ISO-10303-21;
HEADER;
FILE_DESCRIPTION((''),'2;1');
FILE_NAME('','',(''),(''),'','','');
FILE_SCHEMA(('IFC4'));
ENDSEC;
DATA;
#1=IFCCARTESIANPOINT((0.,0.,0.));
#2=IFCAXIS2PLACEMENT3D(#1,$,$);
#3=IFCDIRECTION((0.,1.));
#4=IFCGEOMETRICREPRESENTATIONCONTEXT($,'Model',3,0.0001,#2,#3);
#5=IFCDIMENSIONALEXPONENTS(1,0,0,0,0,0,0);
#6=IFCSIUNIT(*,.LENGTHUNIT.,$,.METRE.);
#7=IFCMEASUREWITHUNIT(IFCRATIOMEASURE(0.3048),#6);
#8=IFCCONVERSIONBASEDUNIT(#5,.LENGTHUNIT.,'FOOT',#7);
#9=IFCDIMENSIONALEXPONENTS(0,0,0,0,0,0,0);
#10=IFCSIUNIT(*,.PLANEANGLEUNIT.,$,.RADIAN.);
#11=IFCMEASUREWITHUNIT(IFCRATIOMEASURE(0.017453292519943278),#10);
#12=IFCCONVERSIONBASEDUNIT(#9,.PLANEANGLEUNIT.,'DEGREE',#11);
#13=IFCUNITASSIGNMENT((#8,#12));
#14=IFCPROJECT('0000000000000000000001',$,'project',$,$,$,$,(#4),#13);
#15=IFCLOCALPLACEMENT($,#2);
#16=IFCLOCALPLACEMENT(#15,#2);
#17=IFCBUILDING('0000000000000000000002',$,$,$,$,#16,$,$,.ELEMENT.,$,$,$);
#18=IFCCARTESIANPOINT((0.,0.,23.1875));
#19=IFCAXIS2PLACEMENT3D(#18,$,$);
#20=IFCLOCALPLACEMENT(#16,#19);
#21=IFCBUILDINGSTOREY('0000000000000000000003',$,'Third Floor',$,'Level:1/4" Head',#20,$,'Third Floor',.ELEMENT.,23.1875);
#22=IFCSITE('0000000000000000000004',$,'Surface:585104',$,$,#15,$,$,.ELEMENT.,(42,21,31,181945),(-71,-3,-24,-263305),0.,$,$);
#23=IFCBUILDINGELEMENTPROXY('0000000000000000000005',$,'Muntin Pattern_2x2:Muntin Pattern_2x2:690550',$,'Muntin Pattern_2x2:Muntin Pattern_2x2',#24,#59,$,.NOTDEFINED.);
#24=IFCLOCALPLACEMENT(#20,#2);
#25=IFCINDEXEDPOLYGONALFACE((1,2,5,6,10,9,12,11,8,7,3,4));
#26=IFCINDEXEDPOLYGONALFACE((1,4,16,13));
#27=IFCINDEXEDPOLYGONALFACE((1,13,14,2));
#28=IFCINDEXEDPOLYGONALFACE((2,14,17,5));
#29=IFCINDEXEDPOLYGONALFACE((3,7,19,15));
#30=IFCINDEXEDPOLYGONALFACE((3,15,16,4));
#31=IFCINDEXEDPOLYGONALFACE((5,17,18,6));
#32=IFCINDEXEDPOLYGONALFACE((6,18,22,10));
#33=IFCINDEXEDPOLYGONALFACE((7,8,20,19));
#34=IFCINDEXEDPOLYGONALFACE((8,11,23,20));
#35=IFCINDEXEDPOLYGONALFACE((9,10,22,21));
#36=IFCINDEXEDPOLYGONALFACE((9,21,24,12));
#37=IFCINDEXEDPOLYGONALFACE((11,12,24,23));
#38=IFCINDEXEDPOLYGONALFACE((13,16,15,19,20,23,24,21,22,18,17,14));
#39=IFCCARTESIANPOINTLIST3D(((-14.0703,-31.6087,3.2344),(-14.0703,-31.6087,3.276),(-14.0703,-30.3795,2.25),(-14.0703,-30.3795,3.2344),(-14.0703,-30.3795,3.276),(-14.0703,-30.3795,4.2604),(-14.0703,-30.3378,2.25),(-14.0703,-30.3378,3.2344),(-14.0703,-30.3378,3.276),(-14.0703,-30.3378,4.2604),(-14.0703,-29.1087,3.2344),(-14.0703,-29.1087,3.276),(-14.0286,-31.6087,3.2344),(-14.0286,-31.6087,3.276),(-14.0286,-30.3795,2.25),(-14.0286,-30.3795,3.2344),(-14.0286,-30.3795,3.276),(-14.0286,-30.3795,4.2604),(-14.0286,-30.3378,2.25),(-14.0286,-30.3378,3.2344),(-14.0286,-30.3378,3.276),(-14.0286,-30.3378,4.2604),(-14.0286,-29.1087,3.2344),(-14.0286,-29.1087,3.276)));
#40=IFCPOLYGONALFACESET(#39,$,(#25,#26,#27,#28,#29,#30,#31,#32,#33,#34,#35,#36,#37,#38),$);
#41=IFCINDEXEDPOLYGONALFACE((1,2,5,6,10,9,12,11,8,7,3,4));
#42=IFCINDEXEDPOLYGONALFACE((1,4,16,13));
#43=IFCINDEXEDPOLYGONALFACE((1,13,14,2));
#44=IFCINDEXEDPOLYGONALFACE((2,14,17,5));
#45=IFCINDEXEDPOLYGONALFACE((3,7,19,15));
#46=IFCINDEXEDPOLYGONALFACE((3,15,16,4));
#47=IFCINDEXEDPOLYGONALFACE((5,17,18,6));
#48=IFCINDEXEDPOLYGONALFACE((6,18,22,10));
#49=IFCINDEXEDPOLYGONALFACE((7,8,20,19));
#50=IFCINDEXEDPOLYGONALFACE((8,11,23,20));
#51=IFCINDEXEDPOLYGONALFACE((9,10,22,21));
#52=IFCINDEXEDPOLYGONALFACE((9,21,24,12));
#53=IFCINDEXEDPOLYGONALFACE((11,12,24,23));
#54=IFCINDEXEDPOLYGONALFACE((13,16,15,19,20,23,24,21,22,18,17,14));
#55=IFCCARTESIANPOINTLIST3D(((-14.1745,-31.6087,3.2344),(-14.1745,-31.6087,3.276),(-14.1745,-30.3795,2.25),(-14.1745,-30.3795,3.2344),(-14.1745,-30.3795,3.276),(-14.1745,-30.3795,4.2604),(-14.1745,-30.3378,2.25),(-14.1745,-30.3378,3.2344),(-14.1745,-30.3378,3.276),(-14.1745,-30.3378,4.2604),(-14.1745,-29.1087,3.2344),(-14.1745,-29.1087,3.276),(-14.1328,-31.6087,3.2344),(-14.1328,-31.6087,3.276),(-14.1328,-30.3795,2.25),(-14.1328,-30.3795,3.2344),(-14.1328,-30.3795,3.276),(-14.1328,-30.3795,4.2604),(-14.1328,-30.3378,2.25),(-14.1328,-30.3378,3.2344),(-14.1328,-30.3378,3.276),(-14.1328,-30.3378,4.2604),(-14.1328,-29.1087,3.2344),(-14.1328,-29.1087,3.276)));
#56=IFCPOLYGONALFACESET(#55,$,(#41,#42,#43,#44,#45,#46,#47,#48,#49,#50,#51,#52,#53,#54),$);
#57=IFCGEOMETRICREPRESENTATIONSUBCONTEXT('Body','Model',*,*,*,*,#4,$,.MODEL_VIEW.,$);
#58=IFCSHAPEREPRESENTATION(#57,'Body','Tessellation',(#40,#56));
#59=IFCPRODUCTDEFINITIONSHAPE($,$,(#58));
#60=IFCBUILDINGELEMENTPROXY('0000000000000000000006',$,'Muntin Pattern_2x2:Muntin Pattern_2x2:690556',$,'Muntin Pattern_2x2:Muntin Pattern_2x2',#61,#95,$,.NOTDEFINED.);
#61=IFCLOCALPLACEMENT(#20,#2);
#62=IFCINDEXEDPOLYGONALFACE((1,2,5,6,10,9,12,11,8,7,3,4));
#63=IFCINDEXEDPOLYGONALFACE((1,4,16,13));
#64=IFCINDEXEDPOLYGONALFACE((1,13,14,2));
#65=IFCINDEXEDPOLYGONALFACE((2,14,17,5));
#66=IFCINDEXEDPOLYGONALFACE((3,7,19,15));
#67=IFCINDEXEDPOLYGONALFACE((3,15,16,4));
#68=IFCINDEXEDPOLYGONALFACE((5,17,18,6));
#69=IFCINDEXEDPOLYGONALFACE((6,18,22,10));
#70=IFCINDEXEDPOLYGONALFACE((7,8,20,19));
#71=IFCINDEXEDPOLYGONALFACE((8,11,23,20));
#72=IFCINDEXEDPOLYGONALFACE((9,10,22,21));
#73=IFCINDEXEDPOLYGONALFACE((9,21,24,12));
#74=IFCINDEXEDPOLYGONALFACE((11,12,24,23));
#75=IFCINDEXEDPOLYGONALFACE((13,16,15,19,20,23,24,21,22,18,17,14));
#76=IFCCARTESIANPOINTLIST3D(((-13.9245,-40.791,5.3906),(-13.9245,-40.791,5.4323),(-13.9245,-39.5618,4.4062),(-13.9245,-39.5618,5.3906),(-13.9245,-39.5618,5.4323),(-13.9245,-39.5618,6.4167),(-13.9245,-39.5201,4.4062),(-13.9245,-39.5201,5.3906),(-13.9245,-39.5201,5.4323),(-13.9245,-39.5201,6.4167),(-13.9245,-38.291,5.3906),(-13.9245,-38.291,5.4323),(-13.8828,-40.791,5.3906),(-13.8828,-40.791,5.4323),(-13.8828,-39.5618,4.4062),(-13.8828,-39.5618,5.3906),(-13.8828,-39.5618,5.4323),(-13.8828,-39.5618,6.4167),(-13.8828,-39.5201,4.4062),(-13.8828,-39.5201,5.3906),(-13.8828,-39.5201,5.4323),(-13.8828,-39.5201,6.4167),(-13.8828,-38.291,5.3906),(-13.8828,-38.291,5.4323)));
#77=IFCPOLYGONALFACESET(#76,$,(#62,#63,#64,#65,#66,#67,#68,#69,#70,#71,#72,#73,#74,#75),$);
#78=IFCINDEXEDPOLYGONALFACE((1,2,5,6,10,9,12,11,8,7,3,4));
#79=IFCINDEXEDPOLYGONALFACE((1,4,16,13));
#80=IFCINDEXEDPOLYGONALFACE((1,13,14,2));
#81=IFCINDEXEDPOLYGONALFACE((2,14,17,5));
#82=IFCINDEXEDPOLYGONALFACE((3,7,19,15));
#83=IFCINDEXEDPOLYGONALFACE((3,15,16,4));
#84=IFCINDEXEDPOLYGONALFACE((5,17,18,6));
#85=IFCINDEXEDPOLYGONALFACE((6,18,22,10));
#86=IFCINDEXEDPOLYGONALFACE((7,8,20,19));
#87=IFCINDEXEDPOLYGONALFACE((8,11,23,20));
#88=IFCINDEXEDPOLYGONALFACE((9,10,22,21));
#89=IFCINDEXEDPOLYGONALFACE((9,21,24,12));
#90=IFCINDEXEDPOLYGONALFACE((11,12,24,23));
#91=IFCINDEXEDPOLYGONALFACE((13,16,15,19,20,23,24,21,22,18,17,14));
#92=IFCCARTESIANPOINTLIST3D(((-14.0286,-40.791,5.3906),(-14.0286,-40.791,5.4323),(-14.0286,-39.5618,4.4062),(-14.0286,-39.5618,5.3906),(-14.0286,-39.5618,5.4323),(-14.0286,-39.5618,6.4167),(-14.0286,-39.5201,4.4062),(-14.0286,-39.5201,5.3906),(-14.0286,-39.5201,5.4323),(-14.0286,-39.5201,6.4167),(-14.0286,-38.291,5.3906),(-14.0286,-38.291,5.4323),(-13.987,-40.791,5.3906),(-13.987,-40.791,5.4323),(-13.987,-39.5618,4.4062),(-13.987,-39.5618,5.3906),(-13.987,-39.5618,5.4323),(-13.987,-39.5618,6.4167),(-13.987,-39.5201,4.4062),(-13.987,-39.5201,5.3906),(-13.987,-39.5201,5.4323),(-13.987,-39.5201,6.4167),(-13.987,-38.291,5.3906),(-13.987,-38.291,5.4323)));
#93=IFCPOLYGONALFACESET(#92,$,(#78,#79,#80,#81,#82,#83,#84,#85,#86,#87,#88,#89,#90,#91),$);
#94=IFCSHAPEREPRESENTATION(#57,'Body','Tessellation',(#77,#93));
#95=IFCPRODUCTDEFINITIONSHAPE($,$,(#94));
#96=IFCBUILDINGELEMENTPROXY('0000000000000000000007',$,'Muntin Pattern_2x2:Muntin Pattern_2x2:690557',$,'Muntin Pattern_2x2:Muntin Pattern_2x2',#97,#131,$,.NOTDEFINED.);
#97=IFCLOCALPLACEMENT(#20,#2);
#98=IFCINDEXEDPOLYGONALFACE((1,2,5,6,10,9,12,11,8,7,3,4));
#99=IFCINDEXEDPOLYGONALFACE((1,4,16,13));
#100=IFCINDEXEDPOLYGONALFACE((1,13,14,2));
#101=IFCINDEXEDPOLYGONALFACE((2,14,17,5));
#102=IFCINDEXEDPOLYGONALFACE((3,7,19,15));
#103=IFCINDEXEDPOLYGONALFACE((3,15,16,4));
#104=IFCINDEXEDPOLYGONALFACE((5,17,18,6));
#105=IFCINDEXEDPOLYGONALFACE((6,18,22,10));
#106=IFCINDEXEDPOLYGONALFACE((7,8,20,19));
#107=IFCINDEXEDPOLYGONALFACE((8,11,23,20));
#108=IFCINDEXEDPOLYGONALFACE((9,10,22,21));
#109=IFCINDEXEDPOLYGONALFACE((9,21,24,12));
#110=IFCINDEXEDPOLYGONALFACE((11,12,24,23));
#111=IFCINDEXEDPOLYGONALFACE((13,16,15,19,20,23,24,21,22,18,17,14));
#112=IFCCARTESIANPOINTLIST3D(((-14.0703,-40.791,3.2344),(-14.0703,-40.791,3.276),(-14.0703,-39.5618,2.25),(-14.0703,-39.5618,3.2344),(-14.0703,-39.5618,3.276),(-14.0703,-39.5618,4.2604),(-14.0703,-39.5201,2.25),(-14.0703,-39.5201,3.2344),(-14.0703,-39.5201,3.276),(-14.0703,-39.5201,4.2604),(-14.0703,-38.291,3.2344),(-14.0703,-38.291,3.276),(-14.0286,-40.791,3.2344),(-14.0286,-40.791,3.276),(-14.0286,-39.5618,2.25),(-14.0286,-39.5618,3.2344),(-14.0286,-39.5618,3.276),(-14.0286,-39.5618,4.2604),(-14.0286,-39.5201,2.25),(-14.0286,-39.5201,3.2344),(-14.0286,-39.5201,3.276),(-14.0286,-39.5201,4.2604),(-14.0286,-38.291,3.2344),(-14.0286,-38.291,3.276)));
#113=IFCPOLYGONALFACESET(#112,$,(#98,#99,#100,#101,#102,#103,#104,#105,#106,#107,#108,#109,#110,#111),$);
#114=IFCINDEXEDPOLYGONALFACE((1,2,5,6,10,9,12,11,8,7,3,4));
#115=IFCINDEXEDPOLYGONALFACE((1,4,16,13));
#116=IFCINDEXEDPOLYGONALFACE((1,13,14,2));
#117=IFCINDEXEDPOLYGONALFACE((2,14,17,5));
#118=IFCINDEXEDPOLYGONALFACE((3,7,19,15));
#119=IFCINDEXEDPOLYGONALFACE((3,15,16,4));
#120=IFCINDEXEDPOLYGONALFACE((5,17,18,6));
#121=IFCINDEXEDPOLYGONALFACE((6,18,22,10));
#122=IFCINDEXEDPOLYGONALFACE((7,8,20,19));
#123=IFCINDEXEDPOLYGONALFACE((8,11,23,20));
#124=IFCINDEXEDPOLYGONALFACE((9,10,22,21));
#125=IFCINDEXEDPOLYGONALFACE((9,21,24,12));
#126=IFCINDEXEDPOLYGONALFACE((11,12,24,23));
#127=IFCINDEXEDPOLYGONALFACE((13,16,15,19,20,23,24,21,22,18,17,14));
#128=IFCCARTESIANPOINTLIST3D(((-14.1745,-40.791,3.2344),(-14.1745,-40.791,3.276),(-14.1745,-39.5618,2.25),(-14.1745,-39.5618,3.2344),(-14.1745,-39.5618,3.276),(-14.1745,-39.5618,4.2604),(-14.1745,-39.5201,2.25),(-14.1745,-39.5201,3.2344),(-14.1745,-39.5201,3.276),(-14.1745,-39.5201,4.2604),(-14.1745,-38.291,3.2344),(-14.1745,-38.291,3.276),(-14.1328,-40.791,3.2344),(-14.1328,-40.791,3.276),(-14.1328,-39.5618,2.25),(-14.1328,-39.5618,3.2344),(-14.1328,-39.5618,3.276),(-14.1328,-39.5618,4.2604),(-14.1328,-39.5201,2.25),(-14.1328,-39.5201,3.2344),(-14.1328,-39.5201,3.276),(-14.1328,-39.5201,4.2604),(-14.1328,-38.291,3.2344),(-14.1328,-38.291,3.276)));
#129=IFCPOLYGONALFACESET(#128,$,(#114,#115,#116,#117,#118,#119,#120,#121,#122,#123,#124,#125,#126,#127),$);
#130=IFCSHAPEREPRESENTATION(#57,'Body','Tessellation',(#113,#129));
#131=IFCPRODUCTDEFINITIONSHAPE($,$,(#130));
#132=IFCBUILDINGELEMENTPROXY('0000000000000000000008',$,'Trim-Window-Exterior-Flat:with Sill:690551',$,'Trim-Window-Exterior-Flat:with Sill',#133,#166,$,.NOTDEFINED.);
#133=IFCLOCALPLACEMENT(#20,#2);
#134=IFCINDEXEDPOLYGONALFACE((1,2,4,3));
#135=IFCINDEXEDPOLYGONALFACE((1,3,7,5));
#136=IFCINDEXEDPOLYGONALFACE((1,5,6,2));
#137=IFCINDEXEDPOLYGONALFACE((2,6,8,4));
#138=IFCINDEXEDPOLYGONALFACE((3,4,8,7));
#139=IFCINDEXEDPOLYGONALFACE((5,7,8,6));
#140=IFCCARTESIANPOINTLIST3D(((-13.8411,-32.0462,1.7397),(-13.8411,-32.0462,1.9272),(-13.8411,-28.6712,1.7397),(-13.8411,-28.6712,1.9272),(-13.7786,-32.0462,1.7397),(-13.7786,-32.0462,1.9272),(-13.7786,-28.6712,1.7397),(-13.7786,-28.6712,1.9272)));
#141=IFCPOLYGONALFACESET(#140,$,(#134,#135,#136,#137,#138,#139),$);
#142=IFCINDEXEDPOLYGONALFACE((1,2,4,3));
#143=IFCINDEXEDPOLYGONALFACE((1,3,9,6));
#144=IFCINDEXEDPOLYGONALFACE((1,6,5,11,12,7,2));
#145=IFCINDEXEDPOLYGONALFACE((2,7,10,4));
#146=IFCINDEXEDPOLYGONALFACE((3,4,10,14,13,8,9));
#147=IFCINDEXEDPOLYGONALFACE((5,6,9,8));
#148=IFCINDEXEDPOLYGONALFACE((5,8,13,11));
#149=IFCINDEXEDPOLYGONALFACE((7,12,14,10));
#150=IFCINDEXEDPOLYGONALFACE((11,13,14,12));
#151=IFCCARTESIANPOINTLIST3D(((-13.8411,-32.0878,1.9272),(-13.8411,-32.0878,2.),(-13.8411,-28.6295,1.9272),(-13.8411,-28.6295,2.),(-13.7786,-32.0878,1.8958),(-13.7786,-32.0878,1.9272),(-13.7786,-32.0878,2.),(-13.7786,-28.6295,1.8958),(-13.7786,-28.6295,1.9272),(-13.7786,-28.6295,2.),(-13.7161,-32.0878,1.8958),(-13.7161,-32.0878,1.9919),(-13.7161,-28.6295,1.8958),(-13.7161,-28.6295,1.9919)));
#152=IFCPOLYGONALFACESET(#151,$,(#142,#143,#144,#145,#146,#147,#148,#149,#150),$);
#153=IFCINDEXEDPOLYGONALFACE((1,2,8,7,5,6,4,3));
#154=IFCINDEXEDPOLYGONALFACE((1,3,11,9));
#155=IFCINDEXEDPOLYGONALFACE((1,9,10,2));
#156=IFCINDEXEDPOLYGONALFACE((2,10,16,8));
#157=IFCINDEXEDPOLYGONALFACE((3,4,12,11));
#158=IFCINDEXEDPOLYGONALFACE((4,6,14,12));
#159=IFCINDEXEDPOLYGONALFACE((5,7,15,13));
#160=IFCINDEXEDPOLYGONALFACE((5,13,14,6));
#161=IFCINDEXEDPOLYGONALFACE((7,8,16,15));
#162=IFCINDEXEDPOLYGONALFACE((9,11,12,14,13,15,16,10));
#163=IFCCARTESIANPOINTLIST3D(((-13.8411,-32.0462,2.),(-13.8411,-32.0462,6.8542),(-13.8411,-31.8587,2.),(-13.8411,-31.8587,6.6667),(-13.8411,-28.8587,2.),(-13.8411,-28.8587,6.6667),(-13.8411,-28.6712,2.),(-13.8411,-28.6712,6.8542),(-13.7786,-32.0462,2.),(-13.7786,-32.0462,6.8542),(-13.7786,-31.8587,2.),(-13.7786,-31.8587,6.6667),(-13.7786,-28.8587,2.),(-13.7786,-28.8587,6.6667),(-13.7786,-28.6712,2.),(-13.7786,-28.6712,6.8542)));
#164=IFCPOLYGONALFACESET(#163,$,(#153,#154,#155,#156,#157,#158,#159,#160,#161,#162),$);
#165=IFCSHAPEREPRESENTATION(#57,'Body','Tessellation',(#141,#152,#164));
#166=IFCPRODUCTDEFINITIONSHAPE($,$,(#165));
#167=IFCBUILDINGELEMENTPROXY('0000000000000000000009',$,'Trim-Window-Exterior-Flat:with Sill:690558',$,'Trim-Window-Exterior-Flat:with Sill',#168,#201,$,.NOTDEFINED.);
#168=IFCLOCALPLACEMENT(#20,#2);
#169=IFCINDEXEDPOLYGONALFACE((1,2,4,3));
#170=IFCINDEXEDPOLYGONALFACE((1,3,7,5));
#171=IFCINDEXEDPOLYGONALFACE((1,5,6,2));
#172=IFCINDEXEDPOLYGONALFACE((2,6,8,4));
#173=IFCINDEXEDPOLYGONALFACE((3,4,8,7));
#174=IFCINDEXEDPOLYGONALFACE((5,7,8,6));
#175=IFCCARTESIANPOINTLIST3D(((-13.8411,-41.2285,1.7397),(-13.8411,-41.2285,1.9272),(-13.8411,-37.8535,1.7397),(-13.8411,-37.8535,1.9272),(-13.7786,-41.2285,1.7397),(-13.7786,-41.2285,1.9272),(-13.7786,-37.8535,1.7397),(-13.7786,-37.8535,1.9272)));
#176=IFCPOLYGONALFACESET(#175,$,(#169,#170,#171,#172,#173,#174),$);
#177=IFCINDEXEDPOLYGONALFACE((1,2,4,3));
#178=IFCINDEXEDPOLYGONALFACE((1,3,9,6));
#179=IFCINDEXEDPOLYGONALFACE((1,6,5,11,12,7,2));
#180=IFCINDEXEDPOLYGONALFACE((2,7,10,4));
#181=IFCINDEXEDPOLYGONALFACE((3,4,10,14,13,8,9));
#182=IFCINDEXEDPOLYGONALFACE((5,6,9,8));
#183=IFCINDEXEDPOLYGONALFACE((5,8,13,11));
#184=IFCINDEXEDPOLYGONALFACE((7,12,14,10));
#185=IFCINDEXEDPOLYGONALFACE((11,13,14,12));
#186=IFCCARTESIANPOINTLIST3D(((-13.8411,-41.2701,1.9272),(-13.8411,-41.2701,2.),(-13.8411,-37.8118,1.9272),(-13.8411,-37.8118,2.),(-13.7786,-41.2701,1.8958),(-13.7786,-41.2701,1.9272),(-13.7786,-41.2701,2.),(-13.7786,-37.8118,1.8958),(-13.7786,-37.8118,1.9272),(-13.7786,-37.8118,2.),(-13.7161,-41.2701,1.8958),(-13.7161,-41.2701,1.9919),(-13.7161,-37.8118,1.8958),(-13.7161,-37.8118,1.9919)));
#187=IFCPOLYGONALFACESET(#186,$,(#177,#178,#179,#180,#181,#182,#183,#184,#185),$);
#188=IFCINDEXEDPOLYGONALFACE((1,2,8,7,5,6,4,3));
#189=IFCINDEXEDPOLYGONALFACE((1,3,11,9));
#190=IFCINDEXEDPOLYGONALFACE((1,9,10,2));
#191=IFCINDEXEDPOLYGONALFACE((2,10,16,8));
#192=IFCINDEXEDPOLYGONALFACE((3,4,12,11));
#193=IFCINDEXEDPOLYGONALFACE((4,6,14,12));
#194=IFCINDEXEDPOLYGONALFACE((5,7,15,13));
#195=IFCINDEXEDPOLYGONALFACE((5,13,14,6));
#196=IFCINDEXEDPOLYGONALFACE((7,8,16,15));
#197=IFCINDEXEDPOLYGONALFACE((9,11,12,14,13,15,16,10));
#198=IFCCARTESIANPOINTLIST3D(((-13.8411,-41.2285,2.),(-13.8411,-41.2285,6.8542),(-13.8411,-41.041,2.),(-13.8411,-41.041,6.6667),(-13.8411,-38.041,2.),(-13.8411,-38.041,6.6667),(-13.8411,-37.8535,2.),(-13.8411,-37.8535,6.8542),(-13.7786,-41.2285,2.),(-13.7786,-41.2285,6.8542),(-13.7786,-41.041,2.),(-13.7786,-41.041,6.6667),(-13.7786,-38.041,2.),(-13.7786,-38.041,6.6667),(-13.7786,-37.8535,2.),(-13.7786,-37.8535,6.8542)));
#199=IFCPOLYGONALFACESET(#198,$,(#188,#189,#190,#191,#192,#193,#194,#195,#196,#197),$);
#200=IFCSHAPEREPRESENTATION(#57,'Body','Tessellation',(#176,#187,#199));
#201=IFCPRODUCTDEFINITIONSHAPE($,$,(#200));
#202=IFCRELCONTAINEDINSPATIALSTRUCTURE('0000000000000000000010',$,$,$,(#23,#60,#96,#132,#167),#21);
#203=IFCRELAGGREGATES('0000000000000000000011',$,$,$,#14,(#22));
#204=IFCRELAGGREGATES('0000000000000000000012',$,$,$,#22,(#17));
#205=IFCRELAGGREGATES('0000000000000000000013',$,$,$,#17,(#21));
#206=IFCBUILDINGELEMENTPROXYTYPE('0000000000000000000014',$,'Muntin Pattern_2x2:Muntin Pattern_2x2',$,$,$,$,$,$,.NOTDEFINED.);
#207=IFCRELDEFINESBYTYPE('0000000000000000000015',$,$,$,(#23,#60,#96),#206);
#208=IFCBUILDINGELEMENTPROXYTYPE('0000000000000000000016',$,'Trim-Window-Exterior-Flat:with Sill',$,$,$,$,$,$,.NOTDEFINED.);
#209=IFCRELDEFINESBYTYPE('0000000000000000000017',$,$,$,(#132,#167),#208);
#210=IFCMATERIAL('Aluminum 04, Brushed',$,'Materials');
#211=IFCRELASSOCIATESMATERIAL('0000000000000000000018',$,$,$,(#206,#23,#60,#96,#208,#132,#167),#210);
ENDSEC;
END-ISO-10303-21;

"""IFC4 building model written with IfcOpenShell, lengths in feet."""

from ifc_helpers import new_model, entity, si_unit, converted_unit, direction, frame, origin, place, context, subcontext, project, spatial, indexed_curve, outline, extrude, source, transform, mapped, material, type_object, type_shapes, element, save


model = new_model("IFC4")

# Units and contexts
model_context = context("Model", 3, precision=0.0001, world=origin(), true_north=direction((0.0, 1.0)))
body_context = subcontext(model_context, "Body", "Model", "MODEL_VIEW")
ifc_project = project(units=[converted_unit("LENGTHUNIT", "FOOT", entity("IfcRatioMeasure", 0.3048), si_unit("LENGTHUNIT", "METRE"), dimensions=[1, 0, 0, 0, 0, 0, 0]), converted_unit("PLANEANGLEUNIT", "DEGREE", entity("IfcRatioMeasure", 0.017453292519943278), si_unit("PLANEANGLEUNIT", "RADIAN"), dimensions=[0, 0, 0, 0, 0, 0, 0])], contexts=[model_context])

# Site, building, storey
site_placement = place(None, origin())
site = spatial("IfcSite", under=ifc_project, at=site_placement, Name="Surface:585104", CompositionType="ELEMENT", RefLatitude=(42, 21, 31, 181945), RefLongitude=(-71, -3, -24, -263305), RefElevation=0.0)
building_placement = place(site_placement, origin())
building = spatial("IfcBuilding", under=site, at=building_placement, CompositionType="ELEMENT")
storey_placement = place(building_placement, frame((0.0, 0.0, 23.1875)))
storey = spatial("IfcBuildingStorey", under=building, at=storey_placement, Name="Third Floor", ObjectType="Level:1/4\" Head", LongName="Third Floor", CompositionType="ELEMENT", Elevation=23.1875)

# Shared definitions
ifc_material_1 = material(Name="Aluminum 04, Brushed", Category="Materials")

# Building element proxies
building_element_proxy_type_1 = type_object("IfcBuildingElementProxyType", Name="Muntin Pattern_2x2:Muntin Pattern_2x2", PredefinedType="NOTDEFINED", material=ifc_material_1)
shared_shape_1 = source(origin(), body_context, "Body", "SweptSolid", [
    extrude(outline(indexed_curve([(0.0208, -0.0208), (1.0052, -0.0208), (1.0052, 0.0208), (0.0208, 0.0208), (0.0208, 1.25), (-0.0208, 1.25), (-0.0208, 0.0208), (-1.0052, 0.0208), (-1.0052, -0.0208), (-0.0208, -0.0208), (-0.0208, -1.25), (0.0208, -1.25), (0.0208, -0.0208)], self_intersect=False)), frame((0.0, -0.0729, 1.0052), z_axis=(0.0, 1.0, 0.0), x_axis=(0.0, 0.0, 1.0)), (0.0, 0.0, 1.0), 0.0417),
    extrude(outline(indexed_curve([(0.0208, -0.0208), (1.0052, -0.0208), (1.0052, 0.0208), (0.0208, 0.0208), (0.0208, 1.25), (-0.0208, 1.25), (-0.0208, 0.0208), (-1.0052, 0.0208), (-1.0052, -0.0208), (-0.0208, -0.0208), (-0.0208, -1.25), (0.0208, -1.25), (0.0208, -0.0208)], self_intersect=False)), frame((0.0, 0.0313, 1.0052), z_axis=(0.0, 1.0, 0.0), x_axis=(0.0, 0.0, 1.0)), (0.0, 0.0, 1.0), 0.0417),
])
type_shapes(building_element_proxy_type_1, [shared_shape_1])
for number, where, z_axis, x_axis, name in (
    (1, (-14.1015, -30.3587, 2.25), (0.0, 0.0, 1.0), (0.0, 1.0, 0.0), "Muntin Pattern_2x2:Muntin Pattern_2x2:690550"),
    (2, (-13.9557, -39.541, 4.4062), (0.0, 0.0, 1.0), (0.0, 1.0, 0.0), "Muntin Pattern_2x2:Muntin Pattern_2x2:690556"),
    (3, (-14.1015, -39.541, 2.25), (0.0, 0.0, 1.0), (0.0, 1.0, 0.0), "Muntin Pattern_2x2:Muntin Pattern_2x2:690557"),
):
    element("IfcBuildingElementProxy", number, at=place(storey_placement, frame(where, z_axis=z_axis, x_axis=x_axis)), inside=storey, type_object=building_element_proxy_type_1, material=ifc_material_1, Name=name, ObjectType="Muntin Pattern_2x2:Muntin Pattern_2x2", PredefinedType="NOTDEFINED", context=body_context, shape_type="MappedRepresentation", body=[
        mapped(shared_shape_1, transform((0.0, 0.0, 0.0), scale=1.0)),
    ])
building_element_proxy_type_2 = type_object("IfcBuildingElementProxyType", Name="Trim-Window-Exterior-Flat:with Sill", PredefinedType="NOTDEFINED", material=ifc_material_1)
shared_shape_2 = source(origin(), body_context, "Body", "SweptSolid", [
    extrude(outline(indexed_curve([(-0.0938, -1.6875), (0.0938, -1.6875), (0.0938, 1.6875), (-0.0938, 1.6875), (-0.0938, -1.6875)], self_intersect=False)), frame((0.0, 4.8332, 0.0), z_axis=(0.0, 0.0, 1.0), x_axis=(0.0, 1.0, 0.0)), (0.0, 0.0, 1.0), 0.0625),
    extrude(outline(indexed_curve([(-0.0525, -0.0625), (0.0436, -0.0625), (0.0517, 0.0), (0.0517, 0.0625), (-0.0211, 0.0625), (-0.0211, 0.0), (-0.0525, 0.0), (-0.0525, -0.0625)], self_intersect=False)), frame((-1.7292, 4.7184, 0.0625), z_axis=(1.0, 0.0, 0.0), x_axis=(0.0, -1.0, 0.0)), (0.0, 0.0, 1.0), 3.4583),
    extrude(outline(indexed_curve([(-1.6875, -2.474), (1.6875, -2.474), (1.6875, 2.3802), (1.5, 2.3802), (1.5, -2.2865), (-1.5, -2.2865), (-1.5, 2.3802), (-1.6875, 2.3802), (-1.6875, -2.474)], self_intersect=False)), frame((0.0, 2.2865, 0.0)), (0.0, 0.0, 1.0), 0.0625),
])
type_shapes(building_element_proxy_type_2, [shared_shape_2])
for number, where, z_axis, x_axis, name in (
    (4, (-13.8411, -30.3587, 6.6667), (1.0, 0.0, 0.0), (0.0, -1.0, 0.0), "Trim-Window-Exterior-Flat:with Sill:690551"),
    (5, (-13.8411, -39.541, 6.6667), (1.0, 0.0, 0.0), (0.0, -1.0, 0.0), "Trim-Window-Exterior-Flat:with Sill:690558"),
):
    element("IfcBuildingElementProxy", number, at=place(storey_placement, frame(where, z_axis=z_axis, x_axis=x_axis)), inside=storey, type_object=building_element_proxy_type_2, material=ifc_material_1, Name=name, ObjectType="Trim-Window-Exterior-Flat:with Sill", PredefinedType="NOTDEFINED", context=body_context, shape_type="MappedRepresentation", body=[
        mapped(shared_shape_2, transform((0.0, 0.0, 0.0), scale=1.0)),
    ])

save(model, "model.ifc")
